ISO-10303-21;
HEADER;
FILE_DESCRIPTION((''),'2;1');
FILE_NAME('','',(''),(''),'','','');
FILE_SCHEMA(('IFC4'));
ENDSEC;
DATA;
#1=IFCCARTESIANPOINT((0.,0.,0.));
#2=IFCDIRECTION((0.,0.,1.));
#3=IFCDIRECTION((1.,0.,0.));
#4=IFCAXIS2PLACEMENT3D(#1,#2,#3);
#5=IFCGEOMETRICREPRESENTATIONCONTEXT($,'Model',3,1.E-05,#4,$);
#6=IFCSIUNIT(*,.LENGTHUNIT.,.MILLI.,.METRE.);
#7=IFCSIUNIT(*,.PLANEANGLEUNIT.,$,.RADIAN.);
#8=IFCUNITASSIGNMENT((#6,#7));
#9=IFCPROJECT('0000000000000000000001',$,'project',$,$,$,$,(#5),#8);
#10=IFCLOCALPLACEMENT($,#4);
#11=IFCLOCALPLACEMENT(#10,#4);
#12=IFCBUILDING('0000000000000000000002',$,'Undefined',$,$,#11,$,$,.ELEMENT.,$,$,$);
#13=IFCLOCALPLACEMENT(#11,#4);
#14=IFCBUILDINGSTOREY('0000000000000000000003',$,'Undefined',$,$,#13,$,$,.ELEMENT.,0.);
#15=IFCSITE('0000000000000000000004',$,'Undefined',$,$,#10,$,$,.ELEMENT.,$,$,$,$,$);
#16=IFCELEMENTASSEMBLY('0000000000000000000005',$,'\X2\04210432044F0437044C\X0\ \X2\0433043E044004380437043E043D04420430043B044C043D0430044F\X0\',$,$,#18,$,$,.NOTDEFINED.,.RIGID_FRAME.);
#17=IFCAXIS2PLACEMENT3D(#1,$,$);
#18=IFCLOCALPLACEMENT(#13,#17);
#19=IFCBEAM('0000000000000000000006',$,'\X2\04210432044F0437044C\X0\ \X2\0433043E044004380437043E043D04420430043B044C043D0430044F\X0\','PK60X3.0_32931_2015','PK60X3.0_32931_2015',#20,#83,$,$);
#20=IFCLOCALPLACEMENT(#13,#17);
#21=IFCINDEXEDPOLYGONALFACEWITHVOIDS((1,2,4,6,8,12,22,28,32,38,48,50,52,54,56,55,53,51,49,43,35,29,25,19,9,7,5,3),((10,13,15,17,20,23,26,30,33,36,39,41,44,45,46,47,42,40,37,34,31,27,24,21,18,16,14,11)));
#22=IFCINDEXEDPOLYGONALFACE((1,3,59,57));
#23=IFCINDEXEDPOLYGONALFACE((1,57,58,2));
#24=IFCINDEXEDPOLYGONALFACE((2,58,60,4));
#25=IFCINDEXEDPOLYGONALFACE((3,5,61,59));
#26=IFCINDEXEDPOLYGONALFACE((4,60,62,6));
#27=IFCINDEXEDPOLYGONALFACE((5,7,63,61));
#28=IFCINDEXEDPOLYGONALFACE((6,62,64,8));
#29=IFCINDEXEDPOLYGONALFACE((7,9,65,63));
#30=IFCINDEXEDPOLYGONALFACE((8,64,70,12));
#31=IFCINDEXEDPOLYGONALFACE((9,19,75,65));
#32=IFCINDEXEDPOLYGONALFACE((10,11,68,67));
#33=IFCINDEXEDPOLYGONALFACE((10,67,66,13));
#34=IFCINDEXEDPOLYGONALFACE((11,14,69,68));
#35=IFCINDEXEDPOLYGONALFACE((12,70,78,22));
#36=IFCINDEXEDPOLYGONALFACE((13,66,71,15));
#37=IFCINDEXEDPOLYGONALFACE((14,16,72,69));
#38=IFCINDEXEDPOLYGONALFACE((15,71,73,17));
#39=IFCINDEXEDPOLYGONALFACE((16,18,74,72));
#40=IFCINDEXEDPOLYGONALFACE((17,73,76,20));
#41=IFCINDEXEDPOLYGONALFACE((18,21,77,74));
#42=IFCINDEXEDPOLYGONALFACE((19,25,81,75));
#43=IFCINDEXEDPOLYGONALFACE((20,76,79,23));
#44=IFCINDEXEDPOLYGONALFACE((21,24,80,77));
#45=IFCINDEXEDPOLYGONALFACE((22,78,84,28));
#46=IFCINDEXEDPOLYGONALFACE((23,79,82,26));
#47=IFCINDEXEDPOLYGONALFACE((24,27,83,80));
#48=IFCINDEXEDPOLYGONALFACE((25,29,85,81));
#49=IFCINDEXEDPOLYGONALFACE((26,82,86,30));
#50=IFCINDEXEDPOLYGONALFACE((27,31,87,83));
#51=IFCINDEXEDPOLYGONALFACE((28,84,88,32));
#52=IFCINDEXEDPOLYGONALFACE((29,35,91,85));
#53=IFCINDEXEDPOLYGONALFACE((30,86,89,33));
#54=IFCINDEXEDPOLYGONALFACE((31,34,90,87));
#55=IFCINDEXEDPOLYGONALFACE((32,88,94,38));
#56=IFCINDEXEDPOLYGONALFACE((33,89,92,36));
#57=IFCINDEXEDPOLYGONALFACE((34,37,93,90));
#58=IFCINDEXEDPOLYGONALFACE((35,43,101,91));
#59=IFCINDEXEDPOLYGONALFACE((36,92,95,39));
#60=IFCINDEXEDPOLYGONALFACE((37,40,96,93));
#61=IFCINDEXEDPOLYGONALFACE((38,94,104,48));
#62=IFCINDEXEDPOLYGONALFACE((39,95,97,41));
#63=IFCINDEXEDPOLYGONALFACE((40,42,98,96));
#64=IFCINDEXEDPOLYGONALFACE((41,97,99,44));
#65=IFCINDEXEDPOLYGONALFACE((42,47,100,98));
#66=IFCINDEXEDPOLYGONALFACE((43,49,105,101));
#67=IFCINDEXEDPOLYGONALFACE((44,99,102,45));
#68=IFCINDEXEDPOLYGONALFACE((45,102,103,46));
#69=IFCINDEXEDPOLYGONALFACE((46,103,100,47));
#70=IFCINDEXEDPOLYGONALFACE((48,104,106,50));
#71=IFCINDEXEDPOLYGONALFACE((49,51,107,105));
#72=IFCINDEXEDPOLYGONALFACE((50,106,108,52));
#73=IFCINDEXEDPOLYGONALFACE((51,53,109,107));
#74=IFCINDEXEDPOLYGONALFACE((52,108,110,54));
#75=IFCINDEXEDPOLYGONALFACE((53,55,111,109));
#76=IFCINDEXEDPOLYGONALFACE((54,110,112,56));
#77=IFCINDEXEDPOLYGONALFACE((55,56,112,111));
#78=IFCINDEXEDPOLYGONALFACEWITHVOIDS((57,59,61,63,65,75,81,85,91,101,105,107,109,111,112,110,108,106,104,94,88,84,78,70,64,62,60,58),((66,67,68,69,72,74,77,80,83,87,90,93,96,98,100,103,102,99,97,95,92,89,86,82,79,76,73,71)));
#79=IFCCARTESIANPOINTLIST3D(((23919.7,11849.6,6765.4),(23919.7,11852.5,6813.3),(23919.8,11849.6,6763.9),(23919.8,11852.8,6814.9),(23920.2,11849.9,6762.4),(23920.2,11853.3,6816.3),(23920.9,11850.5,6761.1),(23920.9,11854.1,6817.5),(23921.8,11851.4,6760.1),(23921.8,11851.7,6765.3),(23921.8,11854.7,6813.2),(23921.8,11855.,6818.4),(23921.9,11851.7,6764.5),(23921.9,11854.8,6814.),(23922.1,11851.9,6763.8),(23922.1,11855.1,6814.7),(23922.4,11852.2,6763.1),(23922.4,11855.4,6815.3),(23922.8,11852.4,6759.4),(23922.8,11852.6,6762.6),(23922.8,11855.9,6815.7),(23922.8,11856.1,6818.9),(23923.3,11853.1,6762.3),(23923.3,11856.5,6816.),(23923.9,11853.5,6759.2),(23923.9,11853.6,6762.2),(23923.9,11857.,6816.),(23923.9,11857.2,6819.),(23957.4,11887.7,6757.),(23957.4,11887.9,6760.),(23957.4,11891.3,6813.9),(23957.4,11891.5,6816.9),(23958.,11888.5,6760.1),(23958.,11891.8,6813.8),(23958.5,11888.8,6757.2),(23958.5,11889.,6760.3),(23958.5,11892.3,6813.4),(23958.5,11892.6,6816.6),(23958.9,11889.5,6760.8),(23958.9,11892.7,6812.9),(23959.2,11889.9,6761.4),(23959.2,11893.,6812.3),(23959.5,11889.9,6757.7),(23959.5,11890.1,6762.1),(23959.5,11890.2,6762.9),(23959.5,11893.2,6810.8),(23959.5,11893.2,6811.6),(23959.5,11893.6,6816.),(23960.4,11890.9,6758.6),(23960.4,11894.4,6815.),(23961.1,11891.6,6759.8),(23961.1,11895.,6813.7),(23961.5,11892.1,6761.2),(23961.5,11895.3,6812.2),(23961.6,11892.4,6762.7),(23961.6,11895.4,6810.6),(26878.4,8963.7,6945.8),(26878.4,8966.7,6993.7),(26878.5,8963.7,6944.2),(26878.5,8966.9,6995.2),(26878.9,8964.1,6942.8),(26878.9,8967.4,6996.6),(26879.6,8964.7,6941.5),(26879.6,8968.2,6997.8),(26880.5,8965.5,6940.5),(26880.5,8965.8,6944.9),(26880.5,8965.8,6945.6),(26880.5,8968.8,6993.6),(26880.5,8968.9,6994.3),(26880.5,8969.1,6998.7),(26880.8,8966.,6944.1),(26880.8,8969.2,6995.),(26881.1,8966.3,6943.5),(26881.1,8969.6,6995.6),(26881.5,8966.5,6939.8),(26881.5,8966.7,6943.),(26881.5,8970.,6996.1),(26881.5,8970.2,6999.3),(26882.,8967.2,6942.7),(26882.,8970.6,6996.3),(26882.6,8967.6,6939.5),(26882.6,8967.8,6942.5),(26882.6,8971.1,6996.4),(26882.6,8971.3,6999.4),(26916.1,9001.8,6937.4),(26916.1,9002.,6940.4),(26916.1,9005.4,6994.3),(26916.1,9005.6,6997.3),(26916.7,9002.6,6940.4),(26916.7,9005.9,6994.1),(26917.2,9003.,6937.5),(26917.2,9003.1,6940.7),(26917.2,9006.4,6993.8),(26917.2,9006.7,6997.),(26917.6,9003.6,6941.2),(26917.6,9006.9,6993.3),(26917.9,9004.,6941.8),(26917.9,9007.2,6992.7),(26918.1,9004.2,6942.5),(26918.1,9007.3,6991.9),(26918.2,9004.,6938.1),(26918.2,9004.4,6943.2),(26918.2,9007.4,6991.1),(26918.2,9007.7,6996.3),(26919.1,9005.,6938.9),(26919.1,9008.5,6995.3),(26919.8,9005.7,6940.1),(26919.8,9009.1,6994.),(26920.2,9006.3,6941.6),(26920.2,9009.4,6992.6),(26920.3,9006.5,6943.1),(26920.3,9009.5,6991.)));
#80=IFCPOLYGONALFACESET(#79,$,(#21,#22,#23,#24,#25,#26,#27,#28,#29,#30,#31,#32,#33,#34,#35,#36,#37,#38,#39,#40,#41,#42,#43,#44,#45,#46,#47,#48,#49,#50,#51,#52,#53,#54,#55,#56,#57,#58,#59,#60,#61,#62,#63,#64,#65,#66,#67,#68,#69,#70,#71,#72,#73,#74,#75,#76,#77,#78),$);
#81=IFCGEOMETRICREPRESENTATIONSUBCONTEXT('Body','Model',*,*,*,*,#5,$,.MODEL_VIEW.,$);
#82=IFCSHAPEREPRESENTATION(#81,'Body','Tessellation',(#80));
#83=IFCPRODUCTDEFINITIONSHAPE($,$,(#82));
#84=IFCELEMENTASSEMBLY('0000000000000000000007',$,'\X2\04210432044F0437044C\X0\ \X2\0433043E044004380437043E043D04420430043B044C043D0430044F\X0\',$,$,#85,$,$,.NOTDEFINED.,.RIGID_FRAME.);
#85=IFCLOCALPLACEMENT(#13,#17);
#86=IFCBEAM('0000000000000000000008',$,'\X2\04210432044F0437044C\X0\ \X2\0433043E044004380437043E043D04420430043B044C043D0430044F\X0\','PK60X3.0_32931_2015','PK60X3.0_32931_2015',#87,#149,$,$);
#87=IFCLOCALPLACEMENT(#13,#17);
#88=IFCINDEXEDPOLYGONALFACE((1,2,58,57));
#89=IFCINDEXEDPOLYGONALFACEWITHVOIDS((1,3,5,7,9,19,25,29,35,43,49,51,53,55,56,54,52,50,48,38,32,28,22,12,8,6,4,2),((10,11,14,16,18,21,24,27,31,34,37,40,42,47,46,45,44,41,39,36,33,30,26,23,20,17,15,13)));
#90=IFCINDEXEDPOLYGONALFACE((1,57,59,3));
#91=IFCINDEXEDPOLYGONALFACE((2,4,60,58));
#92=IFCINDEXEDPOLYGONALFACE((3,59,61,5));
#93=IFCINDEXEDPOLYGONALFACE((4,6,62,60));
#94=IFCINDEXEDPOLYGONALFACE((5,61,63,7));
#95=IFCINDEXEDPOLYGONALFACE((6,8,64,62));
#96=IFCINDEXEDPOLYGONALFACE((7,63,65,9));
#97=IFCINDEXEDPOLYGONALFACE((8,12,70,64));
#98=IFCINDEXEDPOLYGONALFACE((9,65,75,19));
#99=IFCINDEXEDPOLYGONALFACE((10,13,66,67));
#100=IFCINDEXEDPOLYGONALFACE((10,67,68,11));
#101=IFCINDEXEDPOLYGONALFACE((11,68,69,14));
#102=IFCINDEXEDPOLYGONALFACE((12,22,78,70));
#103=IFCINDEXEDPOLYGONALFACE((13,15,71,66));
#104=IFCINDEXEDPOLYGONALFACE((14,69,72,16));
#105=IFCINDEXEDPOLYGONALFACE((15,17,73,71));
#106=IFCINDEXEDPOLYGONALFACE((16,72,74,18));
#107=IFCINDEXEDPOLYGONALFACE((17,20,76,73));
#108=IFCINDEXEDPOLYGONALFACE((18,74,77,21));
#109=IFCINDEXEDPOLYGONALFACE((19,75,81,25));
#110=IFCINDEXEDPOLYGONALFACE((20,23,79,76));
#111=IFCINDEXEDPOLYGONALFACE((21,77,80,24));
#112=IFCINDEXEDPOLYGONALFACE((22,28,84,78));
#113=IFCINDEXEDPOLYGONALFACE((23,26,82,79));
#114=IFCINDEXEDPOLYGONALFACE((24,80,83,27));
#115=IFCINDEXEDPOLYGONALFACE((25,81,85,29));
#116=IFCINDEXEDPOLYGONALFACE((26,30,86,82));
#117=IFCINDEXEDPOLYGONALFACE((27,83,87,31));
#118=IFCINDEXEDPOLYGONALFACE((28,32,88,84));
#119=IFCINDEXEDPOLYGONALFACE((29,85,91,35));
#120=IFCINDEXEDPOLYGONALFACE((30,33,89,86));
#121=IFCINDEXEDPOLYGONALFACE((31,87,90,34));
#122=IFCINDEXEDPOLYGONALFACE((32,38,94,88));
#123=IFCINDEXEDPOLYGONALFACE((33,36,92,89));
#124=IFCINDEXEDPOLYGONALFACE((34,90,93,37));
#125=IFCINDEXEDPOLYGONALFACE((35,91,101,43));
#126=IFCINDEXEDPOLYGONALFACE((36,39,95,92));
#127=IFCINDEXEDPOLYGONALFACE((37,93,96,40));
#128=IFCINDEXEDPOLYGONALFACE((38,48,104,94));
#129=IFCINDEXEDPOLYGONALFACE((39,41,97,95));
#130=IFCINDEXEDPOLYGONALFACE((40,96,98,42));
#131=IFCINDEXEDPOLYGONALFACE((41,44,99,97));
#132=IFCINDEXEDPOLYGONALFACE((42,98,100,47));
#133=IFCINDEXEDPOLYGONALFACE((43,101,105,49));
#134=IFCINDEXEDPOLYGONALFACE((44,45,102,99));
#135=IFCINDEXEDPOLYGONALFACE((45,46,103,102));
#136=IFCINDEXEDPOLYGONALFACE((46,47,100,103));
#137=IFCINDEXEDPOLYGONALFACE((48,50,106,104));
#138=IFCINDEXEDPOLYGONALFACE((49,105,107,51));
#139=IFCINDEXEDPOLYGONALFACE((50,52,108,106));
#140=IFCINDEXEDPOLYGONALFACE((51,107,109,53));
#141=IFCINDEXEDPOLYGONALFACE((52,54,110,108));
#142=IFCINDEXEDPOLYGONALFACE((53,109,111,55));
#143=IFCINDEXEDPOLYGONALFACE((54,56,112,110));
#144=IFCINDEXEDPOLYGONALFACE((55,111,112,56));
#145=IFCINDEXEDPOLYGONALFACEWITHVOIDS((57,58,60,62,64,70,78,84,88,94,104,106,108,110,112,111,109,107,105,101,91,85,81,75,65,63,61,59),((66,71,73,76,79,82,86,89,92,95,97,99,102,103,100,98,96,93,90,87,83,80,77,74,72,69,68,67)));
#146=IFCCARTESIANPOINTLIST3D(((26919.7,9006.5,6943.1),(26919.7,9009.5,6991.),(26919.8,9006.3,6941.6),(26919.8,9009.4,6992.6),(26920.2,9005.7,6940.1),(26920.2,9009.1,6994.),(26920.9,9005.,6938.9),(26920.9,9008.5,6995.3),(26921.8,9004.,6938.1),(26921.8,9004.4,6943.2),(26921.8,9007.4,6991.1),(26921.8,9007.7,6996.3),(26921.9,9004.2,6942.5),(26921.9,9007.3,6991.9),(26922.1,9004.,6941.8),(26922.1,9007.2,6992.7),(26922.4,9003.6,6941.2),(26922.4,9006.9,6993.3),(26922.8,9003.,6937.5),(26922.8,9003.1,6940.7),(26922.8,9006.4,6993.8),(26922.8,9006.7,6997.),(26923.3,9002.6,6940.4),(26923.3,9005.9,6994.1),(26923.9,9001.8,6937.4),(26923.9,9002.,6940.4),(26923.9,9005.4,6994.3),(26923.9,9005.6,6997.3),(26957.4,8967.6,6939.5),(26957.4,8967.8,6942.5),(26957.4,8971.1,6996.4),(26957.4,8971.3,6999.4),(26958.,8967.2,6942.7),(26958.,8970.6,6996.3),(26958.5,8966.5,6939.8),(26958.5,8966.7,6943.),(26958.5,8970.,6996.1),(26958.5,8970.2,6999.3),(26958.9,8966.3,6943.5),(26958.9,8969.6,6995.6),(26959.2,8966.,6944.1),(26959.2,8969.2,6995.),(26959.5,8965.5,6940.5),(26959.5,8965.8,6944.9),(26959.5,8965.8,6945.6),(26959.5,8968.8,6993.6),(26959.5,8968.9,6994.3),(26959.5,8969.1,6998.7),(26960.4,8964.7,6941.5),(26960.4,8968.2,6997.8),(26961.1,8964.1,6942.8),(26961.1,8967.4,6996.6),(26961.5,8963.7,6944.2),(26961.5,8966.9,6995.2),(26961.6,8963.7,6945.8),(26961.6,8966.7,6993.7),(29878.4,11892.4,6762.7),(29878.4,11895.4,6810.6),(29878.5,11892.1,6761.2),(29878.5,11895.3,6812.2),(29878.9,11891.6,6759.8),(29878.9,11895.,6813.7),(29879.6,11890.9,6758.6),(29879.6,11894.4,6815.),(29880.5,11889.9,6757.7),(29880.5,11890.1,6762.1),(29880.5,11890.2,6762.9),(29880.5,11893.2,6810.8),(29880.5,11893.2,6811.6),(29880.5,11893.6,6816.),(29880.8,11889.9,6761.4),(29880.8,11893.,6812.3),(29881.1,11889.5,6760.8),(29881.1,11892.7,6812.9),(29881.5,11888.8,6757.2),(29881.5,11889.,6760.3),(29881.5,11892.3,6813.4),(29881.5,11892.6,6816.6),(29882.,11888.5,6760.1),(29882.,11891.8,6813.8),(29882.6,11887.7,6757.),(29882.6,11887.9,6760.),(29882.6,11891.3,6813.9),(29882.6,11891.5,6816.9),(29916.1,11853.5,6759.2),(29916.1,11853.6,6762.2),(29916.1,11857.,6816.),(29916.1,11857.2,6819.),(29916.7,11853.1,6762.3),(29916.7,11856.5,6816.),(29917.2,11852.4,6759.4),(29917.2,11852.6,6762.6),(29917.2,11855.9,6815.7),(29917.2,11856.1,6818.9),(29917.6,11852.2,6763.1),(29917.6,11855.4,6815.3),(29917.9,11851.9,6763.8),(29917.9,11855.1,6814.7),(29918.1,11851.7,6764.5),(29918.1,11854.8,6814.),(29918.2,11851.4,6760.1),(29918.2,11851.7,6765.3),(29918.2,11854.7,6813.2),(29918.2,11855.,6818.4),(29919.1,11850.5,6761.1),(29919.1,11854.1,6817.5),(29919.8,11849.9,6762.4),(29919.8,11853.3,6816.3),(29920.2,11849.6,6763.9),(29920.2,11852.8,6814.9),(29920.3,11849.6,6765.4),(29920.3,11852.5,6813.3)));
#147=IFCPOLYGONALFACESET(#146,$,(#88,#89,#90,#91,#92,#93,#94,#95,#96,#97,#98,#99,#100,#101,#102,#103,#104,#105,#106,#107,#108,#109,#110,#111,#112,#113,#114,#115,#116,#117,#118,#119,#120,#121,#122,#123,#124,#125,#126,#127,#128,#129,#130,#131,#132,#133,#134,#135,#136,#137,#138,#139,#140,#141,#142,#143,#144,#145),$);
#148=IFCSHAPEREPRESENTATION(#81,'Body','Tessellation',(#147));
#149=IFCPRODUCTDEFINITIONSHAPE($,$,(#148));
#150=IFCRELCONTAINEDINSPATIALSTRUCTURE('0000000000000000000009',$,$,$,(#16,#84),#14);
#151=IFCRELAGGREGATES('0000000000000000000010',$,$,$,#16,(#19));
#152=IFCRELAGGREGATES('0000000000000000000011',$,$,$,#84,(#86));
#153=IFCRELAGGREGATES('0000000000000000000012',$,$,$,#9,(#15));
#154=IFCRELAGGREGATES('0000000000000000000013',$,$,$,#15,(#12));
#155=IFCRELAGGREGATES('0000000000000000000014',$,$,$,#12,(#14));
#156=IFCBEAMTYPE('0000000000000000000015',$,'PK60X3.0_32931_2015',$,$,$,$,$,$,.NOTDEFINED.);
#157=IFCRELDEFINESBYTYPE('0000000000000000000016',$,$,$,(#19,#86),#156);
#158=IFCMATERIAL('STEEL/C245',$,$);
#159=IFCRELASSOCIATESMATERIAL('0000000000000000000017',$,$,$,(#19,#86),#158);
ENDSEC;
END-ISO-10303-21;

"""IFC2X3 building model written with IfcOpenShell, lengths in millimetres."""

from ifc_helpers import new_model, si_unit, frame, origin_with_axes, origin_2d_with_axis, place, context, subcontext, project, spatial, hollow_rectangle, extrude, material, type_object, element, aggregate, save


model = new_model("IFC2X3")

# Units and contexts
model_context = context("Model", 3, precision=1e-05, world=origin_with_axes())
body_context = subcontext(model_context, "Body", "Model", "MODEL_VIEW")
ifc_project = project(units=[si_unit("LENGTHUNIT", "METRE", prefix="MILLI"), si_unit("PLANEANGLEUNIT", "RADIAN")], contexts=[model_context])

# Site, building, storey
site_placement = place(None, origin_with_axes())
site = spatial("IfcSite", under=ifc_project, at=site_placement, Name="Undefined", CompositionType="ELEMENT")
building_placement = place(site_placement, origin_with_axes())
building = spatial("IfcBuilding", under=site, at=building_placement, Name="Undefined", CompositionType="ELEMENT")
storey_placement = place(building_placement, origin_with_axes())
storey = spatial("IfcBuildingStorey", under=building, at=storey_placement, Name="Undefined", CompositionType="ELEMENT", Elevation=0.0)

# Shared definitions
ifc_material = material(Name="STEEL/C245")

# Element assemblies, beams
assembly_1_placement = place(storey_placement, origin_with_axes())
assembly_1 = element("IfcElementAssembly", 1, at=assembly_1_placement, inside=storey, Name="Связь горизонтальная", AssemblyPlace="NOTDEFINED", PredefinedType="RIGID_FRAME")
beam_type_1 = type_object("IfcBeamType", Name="PK60X3.0_32931_2015", PredefinedType="NOTDEFINED")
beam_1_placement = place(assembly_1_placement, frame((23940.7, 11872.5, 6788.0), z_axis=(0.0, 0.062378, 0.998053), x_axis=(0.715179, -0.69758, 0.043599)))
beam_1 = element("IfcBeam", 2, at=beam_1_placement, type_object=beam_type_1, material=ifc_material, Name="Связь горизонтальная", Description="PK60X3.0_32931_2015", ObjectType="PK60X3.0_32931_2015", context=body_context, shape_type="SweptSolid", body=[
    extrude(hollow_rectangle(XDim=60.0, YDim=60.0, WallThickness=3.0, InnerFilletRadius=3.0, OuterFilletRadius=6.0, at=origin_2d_with_axis()), frame((4137.0, 0.0, 0.0), z_axis=(-1.0, 0.0, 0.0), x_axis=(0.0, -1.0, 0.0)), (0.0, 0.0, 1.0), 4137.0),
])
aggregate(assembly_1, [beam_1])
assembly_2_placement = place(storey_placement, origin_with_axes())
assembly_2 = element("IfcElementAssembly", 3, at=assembly_2_placement, inside=storey, Name="Связь горизонтальная", AssemblyPlace="NOTDEFINED", PredefinedType="RIGID_FRAME")
beam_2_placement = place(assembly_2_placement, frame((29899.3, 11872.5, 6788.0), z_axis=(0.0, 0.062378, 0.998053), x_axis=(-0.715179, -0.69758, 0.043599)))
beam_2 = element("IfcBeam", 4, at=beam_2_placement, type_object=beam_type_1, material=ifc_material, Name="Связь горизонтальная", Description="PK60X3.0_32931_2015", ObjectType="PK60X3.0_32931_2015", context=body_context, shape_type="SweptSolid", body=[
    extrude(hollow_rectangle(XDim=60.0, YDim=60.0, WallThickness=3.0, InnerFilletRadius=3.0, OuterFilletRadius=6.0, at=origin_2d_with_axis()), frame((4137.0, 0.0, 0.0), z_axis=(-1.0, 0.0, 0.0), x_axis=(0.0, -1.0, 0.0)), (0.0, 0.0, 1.0), 4137.0),
])
aggregate(assembly_2, [beam_2])

save(model, "model.ifc")
